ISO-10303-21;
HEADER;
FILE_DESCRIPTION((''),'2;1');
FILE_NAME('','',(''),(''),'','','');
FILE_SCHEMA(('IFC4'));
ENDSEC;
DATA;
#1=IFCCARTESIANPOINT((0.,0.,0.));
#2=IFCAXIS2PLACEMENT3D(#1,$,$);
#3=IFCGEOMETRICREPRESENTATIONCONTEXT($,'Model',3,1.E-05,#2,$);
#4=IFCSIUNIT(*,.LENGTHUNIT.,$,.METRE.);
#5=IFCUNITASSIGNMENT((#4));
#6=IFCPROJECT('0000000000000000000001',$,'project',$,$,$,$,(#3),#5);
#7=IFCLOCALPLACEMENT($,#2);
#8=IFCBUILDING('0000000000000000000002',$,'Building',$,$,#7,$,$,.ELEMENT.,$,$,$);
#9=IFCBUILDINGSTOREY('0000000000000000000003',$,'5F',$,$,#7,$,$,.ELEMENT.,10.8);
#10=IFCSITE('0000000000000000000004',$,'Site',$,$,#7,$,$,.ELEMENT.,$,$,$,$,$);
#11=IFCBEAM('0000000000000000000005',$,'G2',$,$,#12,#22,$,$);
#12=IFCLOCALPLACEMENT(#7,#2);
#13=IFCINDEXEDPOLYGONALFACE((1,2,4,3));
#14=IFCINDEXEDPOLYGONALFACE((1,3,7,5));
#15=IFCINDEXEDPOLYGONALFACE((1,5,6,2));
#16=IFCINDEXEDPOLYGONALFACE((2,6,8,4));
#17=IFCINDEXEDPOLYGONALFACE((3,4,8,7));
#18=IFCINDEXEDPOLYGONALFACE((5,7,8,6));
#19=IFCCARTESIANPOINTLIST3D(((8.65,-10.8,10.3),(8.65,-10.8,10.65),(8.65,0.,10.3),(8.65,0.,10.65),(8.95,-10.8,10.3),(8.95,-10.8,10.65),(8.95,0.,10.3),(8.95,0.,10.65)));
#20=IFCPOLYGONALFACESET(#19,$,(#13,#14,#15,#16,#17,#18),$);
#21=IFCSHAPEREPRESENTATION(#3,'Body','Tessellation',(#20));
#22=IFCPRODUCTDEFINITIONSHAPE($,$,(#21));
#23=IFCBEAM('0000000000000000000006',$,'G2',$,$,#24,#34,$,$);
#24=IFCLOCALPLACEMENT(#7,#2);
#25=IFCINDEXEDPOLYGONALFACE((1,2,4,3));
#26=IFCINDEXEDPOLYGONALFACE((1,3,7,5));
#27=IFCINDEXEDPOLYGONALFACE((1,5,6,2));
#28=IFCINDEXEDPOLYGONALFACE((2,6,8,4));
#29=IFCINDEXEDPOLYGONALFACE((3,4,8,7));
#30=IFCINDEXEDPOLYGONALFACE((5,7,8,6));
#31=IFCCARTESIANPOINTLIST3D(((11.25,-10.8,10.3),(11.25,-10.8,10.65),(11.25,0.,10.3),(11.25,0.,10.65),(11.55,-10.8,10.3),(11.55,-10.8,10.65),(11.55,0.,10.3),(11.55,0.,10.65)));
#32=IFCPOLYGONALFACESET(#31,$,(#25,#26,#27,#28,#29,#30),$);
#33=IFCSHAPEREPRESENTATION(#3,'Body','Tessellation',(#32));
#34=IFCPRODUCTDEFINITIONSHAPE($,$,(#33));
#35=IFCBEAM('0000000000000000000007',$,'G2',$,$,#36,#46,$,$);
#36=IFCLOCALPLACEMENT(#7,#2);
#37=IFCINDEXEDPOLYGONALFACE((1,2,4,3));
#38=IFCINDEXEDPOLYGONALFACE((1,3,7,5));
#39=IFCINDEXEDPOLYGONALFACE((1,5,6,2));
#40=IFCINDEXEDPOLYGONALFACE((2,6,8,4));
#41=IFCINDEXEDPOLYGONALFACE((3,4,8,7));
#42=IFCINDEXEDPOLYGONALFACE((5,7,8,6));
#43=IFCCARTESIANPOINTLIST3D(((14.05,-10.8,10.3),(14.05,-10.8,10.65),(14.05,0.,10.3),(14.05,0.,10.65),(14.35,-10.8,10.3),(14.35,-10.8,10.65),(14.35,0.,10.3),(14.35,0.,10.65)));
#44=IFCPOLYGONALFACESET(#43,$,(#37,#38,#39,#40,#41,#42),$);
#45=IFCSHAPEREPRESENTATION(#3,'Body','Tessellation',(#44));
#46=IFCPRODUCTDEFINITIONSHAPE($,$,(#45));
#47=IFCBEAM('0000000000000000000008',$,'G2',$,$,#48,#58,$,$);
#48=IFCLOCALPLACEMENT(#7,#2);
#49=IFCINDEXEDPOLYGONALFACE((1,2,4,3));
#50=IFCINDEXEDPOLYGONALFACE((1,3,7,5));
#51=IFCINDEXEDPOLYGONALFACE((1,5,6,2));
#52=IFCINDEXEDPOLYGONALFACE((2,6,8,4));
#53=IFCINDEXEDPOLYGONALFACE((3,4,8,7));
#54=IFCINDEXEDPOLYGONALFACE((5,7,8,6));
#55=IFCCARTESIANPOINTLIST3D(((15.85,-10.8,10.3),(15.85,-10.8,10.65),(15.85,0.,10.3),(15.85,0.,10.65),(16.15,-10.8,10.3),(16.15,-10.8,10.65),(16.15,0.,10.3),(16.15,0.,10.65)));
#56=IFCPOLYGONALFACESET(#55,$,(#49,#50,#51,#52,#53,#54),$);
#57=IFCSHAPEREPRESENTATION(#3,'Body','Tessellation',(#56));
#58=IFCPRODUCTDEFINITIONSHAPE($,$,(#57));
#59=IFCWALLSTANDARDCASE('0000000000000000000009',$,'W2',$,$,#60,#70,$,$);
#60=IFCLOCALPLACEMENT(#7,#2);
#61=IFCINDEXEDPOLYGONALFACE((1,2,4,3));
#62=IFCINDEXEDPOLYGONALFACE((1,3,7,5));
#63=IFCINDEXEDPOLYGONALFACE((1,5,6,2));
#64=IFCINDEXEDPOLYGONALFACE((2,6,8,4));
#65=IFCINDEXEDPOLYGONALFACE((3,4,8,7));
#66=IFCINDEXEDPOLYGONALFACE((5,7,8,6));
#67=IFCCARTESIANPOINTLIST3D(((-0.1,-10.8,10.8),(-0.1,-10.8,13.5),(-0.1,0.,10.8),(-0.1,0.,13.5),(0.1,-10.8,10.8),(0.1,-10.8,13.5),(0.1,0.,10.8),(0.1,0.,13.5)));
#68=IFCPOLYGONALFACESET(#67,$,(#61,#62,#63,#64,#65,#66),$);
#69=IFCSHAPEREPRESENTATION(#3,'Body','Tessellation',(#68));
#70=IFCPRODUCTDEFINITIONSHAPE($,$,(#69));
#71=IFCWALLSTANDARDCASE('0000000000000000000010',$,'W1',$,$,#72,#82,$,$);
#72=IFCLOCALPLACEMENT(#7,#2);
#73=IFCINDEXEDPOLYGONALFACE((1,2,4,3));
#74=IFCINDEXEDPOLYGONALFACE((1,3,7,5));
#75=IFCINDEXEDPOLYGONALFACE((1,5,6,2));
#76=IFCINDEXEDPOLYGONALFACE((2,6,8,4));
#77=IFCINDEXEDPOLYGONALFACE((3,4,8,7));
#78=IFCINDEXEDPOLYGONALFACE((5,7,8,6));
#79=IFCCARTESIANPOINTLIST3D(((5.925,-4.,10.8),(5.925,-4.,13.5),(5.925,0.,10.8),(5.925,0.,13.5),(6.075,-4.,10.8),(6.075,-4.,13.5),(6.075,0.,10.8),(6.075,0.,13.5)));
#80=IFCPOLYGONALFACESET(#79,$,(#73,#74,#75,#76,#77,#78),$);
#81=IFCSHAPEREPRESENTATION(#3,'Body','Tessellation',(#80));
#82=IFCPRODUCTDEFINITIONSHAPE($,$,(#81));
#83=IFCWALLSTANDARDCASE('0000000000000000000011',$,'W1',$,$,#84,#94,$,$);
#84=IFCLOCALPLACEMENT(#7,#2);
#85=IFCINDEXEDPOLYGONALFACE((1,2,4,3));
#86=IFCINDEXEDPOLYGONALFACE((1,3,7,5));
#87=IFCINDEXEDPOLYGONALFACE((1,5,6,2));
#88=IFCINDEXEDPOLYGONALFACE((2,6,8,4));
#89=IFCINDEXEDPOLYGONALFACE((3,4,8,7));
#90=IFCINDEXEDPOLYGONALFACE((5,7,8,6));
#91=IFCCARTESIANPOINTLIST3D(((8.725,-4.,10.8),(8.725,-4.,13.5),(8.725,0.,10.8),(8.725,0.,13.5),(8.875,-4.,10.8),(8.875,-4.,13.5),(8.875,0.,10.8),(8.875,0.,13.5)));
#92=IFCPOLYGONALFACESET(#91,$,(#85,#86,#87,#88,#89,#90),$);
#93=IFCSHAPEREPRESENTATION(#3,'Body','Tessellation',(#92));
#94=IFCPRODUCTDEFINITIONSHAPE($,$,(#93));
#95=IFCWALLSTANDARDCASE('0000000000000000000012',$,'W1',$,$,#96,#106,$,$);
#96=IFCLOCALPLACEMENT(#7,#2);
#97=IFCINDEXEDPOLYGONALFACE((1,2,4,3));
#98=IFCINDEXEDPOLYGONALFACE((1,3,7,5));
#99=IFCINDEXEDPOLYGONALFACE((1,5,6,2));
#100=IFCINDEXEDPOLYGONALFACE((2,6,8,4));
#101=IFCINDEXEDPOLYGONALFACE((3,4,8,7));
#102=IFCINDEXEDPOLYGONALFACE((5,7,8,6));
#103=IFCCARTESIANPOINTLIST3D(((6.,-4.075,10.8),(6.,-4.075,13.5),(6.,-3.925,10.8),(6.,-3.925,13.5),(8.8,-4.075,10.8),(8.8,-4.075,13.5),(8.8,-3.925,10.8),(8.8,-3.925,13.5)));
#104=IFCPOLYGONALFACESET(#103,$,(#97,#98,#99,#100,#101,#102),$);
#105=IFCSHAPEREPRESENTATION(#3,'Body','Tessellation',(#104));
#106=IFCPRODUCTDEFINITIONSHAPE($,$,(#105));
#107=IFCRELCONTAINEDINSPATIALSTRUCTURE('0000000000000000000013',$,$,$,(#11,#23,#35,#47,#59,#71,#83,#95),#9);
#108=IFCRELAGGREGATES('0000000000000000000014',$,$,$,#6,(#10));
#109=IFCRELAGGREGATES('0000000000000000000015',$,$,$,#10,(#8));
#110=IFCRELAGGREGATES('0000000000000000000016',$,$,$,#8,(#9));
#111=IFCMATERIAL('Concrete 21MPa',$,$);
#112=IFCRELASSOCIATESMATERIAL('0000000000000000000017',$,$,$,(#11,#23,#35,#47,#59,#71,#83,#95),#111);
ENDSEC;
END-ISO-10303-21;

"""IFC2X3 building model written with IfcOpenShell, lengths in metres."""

from ifc_helpers import new_model, si_unit, frame, origin, origin_2d, place, context, project, spatial, rectangle, extrude, material, element, save


model = new_model("IFC2X3")

# Units and contexts
model_context = context("Model", 3, precision=1e-05, world=origin())
ifc_project = project(units=[si_unit("LENGTHUNIT", "METRE")], contexts=[model_context])

# Site, building, storey
placement = place(None, origin())
site = spatial("IfcSite", under=ifc_project, at=placement, Name="Site", CompositionType="ELEMENT")
building = spatial("IfcBuilding", under=site, at=placement, Name="Building", CompositionType="ELEMENT")
storey = spatial("IfcBuildingStorey", under=building, at=placement, Name="5F", CompositionType="ELEMENT", Elevation=10.8)

# Shared definitions
ifc_material = material(Name="Concrete 21MPa")

# Beams
for number, where, name in (
    (1, (8.8, -5.4, 10.3), "G2"),
    (2, (11.4, -5.4, 10.3), "G2"),
    (3, (14.2, -5.4, 10.3), "G2"),
    (4, (16.0, -5.4, 10.3), "G2"),
):
    element("IfcBeam", number, at=place(None, frame(where)), inside=storey, material=ifc_material, Name=name, context=model_context, shape_type="SweptSolid", body=[
        extrude(rectangle(XDim=0.3, YDim=10.8, at=origin_2d()), origin(), (0.0, 0.0, 1.0), 0.35),
    ])

# Walls
wall_1_placement = place(None, frame((0.0, -5.4, 10.8)))
element("IfcWallStandardCase", 5, at=wall_1_placement, inside=storey, material=ifc_material, Name="W2", context=model_context, shape_type="SweptSolid", body=[
    extrude(rectangle(XDim=0.2, YDim=10.8, at=origin_2d()), origin(), (0.0, 0.0, 1.0), 2.7),
])
for number, where, name in (
    (6, (6.0, -2.0, 10.8), "W1"),
    (7, (8.8, -2.0, 10.8), "W1"),
):
    element("IfcWallStandardCase", number, at=place(None, frame(where)), inside=storey, material=ifc_material, Name=name, context=model_context, shape_type="SweptSolid", body=[
        extrude(rectangle(XDim=0.15, YDim=4.0, at=origin_2d()), origin(), (0.0, 0.0, 1.0), 2.7),
    ])
wall_2_placement = place(None, frame((7.4, -4.0, 10.8)))
element("IfcWallStandardCase", 8, at=wall_2_placement, inside=storey, material=ifc_material, Name="W1", context=model_context, shape_type="SweptSolid", body=[
    extrude(rectangle(XDim=2.8, YDim=0.15, at=origin_2d()), origin(), (0.0, 0.0, 1.0), 2.7),
])

save(model, "model.ifc")
